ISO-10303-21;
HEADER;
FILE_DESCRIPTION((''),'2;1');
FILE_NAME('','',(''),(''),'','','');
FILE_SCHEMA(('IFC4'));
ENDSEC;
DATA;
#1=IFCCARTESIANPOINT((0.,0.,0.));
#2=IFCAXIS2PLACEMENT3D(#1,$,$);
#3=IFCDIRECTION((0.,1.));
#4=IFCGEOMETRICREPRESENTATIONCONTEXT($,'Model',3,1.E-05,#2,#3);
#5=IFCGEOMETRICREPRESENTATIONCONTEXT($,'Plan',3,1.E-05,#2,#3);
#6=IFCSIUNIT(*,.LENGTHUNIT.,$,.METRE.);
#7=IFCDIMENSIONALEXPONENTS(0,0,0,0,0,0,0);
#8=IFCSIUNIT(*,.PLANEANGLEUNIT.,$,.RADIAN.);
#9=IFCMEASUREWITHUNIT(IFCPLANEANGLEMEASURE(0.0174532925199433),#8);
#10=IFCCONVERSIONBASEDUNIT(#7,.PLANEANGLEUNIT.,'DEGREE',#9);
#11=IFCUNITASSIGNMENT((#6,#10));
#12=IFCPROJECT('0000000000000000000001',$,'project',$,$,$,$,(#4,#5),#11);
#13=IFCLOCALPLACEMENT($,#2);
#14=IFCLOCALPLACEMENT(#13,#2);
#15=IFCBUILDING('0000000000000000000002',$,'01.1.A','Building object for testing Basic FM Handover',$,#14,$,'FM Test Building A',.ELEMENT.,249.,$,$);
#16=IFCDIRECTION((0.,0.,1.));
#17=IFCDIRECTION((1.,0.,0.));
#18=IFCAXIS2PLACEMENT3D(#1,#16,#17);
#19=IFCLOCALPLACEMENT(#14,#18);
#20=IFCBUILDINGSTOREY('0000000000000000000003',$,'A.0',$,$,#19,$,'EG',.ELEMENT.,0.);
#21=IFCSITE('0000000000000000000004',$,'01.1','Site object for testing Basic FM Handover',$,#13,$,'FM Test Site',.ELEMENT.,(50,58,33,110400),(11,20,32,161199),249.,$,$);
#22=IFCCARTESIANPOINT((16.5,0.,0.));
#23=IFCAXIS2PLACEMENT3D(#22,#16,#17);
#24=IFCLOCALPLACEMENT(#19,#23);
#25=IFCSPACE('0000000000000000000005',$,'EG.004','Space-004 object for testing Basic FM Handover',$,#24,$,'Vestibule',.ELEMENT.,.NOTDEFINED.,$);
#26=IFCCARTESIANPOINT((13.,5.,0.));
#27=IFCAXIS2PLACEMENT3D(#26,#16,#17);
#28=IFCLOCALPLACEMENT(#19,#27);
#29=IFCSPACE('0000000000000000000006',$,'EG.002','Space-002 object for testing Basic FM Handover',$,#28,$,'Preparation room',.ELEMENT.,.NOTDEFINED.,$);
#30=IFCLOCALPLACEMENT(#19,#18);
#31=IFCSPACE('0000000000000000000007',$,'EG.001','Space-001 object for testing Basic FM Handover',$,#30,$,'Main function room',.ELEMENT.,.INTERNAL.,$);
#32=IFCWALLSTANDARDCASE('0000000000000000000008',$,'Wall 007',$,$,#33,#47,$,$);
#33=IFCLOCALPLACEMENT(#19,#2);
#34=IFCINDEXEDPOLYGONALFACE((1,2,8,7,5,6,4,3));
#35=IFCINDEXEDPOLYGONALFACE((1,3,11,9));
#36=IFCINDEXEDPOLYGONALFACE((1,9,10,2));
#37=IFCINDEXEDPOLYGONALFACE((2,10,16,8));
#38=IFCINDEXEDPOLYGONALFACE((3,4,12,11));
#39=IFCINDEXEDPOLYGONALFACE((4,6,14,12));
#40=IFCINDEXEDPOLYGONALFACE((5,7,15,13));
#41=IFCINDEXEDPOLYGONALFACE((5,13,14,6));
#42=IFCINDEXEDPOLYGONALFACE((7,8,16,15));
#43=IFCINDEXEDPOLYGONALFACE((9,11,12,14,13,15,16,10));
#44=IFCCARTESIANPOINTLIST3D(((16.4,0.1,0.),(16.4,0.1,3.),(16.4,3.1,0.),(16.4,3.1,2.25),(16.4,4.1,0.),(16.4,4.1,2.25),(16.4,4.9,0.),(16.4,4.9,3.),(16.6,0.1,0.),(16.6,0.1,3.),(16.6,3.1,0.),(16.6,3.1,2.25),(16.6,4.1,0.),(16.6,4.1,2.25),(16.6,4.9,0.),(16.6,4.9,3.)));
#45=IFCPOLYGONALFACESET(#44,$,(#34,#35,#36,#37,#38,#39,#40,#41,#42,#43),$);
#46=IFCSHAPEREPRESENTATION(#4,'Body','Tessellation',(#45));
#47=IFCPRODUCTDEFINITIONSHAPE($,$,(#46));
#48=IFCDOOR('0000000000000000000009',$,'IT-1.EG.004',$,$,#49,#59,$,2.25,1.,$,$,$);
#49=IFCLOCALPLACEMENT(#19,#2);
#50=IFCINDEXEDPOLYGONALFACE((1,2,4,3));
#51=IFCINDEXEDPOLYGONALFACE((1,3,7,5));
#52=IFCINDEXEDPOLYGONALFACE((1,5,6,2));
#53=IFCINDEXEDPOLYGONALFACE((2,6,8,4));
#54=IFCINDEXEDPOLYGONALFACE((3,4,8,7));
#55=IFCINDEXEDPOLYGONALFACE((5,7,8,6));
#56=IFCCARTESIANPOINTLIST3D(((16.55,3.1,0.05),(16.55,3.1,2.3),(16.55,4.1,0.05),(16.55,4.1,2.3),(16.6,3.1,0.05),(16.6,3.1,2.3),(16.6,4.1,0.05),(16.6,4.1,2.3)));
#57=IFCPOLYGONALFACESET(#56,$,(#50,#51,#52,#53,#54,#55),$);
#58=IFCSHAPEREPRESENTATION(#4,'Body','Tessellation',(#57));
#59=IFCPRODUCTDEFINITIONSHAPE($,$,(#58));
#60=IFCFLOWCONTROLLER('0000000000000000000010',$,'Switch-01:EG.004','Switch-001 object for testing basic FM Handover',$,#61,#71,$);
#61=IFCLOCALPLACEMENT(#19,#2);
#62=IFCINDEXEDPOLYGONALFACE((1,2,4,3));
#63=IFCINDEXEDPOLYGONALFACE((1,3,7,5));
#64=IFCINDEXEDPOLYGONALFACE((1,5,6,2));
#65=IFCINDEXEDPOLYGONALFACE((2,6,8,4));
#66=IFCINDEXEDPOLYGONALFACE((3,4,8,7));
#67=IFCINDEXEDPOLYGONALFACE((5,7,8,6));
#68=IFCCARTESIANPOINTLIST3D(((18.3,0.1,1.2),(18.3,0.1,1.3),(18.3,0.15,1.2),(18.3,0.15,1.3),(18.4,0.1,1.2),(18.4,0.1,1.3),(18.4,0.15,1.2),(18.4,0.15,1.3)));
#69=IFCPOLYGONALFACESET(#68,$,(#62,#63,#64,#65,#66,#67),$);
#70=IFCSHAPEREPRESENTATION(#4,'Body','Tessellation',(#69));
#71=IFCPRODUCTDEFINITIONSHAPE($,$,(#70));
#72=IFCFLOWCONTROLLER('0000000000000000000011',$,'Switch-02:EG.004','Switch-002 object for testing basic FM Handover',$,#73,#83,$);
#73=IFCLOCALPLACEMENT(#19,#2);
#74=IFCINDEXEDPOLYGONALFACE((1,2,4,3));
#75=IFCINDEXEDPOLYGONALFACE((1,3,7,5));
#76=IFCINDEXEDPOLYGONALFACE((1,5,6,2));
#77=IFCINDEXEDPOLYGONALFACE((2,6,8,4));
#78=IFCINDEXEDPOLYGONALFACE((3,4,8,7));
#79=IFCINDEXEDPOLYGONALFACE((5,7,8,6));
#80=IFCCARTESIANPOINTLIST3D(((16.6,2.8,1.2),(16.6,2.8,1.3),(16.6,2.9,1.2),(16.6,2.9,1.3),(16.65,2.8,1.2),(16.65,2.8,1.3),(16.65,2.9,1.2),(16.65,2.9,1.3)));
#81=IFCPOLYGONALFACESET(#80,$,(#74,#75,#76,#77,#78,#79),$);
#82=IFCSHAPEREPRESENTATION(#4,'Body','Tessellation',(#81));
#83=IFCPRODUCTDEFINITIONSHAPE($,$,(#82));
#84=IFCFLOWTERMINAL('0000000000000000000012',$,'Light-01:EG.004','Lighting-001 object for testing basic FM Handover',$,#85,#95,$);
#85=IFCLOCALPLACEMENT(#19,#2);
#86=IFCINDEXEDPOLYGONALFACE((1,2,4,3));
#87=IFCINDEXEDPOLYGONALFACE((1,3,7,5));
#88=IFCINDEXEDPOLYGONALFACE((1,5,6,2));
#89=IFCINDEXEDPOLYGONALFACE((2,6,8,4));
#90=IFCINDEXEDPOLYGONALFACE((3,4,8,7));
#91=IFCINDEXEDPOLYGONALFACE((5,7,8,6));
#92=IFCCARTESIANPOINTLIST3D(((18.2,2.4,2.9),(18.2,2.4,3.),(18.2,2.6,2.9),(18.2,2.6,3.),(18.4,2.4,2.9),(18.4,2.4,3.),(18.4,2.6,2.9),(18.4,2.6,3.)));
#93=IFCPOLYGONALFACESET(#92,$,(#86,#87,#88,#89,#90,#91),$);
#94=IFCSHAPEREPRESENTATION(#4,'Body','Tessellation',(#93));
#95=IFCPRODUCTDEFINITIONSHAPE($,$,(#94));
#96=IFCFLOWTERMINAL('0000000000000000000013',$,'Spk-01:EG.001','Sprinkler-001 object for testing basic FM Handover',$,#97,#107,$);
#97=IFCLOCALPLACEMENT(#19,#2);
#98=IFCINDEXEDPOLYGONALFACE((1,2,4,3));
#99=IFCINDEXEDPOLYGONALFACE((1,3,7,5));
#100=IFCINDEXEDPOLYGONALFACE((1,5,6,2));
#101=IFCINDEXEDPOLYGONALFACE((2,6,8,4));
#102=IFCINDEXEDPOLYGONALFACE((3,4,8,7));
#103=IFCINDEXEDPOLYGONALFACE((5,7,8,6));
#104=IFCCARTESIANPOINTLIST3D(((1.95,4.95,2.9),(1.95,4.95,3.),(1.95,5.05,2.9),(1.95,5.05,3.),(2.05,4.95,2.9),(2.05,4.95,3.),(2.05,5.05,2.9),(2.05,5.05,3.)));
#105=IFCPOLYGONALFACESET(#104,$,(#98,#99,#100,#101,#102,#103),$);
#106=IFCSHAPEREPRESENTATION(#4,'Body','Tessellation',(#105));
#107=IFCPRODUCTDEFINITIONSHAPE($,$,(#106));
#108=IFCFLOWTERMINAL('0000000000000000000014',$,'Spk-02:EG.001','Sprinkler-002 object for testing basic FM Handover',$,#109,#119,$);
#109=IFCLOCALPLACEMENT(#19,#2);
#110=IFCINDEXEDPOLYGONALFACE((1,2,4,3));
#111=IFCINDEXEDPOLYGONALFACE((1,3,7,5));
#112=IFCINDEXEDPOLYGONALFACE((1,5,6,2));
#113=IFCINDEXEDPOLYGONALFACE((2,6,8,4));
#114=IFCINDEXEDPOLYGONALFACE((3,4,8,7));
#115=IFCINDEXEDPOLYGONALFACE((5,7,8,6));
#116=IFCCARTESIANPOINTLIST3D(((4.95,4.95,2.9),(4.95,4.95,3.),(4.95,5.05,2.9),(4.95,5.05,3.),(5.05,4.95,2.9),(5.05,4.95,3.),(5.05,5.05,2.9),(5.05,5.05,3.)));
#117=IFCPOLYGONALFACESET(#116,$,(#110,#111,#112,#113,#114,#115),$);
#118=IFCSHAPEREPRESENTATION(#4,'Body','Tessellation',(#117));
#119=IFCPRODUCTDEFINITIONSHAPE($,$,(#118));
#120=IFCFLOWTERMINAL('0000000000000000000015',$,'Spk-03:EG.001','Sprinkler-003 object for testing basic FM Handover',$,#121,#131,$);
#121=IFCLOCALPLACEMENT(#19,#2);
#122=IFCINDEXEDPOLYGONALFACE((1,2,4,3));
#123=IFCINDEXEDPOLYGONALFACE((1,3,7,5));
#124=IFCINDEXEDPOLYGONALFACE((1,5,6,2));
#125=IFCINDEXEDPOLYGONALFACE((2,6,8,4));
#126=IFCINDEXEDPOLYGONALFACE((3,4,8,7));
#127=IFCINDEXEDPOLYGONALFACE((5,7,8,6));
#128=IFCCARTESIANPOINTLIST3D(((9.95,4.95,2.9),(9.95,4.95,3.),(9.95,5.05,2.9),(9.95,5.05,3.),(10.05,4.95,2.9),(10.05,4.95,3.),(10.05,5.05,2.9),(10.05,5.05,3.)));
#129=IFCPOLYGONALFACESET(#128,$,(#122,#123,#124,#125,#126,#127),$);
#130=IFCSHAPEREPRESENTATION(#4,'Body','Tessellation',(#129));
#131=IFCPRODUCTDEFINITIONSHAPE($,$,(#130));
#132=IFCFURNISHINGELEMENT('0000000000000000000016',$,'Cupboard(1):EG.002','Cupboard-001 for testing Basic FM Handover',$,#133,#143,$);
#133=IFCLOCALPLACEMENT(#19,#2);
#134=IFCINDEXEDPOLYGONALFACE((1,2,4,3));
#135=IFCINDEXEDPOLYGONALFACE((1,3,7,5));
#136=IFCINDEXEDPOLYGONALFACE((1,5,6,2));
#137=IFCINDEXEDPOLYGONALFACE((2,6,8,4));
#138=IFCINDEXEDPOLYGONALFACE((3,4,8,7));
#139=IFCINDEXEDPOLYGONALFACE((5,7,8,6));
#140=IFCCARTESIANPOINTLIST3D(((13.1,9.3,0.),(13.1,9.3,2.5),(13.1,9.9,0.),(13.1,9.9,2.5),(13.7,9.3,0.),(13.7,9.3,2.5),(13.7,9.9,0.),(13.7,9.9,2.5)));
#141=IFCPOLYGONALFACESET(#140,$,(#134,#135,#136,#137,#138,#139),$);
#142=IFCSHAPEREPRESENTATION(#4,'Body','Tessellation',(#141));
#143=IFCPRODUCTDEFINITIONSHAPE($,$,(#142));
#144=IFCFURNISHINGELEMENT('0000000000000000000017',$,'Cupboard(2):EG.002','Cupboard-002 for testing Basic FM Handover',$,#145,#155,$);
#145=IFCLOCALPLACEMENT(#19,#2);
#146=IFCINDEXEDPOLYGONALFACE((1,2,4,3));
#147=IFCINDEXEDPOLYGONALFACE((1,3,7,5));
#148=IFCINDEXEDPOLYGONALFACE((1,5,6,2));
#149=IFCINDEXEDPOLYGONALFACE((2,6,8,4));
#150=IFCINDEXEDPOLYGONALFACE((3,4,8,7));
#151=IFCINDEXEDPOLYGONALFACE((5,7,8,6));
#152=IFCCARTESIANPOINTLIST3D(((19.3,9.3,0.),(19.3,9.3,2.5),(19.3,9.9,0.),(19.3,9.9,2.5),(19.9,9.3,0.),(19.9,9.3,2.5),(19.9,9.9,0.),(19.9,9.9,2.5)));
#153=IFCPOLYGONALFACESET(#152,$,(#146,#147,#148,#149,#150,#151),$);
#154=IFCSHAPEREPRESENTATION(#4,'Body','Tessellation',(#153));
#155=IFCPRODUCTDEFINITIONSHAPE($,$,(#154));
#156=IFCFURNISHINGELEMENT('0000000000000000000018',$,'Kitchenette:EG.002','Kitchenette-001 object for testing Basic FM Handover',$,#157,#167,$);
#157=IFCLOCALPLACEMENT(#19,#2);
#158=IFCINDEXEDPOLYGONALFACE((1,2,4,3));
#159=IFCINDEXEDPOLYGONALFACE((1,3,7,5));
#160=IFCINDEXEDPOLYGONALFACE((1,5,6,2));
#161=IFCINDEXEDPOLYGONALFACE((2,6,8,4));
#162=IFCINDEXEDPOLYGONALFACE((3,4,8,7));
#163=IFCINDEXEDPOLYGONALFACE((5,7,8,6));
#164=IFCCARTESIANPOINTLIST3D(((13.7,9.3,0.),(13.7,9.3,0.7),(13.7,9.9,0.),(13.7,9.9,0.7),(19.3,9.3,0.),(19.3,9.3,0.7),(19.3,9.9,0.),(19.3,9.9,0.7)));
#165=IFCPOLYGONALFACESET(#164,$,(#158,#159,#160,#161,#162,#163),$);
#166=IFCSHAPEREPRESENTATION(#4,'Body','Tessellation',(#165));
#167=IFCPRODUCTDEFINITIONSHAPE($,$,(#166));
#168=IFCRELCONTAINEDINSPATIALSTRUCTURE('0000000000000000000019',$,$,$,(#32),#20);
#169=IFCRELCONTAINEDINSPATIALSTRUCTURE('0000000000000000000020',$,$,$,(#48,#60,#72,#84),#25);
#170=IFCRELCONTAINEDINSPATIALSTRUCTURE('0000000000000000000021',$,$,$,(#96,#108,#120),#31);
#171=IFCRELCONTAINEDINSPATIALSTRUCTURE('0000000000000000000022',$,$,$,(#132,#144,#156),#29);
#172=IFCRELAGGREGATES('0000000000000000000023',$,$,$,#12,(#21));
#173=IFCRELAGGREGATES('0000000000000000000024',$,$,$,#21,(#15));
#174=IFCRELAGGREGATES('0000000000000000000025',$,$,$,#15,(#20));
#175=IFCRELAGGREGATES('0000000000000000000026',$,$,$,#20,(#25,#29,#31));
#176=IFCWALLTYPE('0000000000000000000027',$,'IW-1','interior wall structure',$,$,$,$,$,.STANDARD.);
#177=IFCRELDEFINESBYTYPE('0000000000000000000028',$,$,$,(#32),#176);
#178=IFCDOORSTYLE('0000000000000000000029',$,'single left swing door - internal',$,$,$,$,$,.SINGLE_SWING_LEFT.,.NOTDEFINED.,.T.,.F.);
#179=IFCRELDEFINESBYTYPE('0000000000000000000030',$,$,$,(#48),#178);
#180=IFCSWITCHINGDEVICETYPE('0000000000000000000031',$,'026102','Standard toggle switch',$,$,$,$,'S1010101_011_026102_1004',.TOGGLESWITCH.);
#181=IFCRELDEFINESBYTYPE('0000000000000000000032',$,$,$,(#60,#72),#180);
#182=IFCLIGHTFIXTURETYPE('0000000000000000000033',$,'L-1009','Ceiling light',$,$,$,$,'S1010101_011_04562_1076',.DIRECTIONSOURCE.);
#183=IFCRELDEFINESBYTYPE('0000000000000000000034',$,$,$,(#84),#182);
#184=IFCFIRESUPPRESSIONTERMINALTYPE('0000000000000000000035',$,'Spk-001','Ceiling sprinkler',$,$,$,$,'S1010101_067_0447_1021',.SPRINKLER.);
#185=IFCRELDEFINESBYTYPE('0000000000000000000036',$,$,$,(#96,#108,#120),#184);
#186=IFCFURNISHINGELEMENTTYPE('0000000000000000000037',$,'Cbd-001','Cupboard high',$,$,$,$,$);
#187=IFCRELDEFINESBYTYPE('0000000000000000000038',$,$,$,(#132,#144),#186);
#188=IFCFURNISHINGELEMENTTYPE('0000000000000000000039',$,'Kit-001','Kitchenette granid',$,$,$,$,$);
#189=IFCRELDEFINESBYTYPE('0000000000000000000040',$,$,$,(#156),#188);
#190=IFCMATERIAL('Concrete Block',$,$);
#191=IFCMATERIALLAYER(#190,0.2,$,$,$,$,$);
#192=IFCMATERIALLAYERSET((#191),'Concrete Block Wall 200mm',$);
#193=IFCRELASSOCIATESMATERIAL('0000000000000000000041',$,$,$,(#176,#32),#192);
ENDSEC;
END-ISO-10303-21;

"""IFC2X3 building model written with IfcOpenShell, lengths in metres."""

from ifc_helpers import new_model, entity, si_unit, converted_unit, direction, frame, frame_2d, origin, origin_with_axes, place, context, project, spatial, polyline, rectangle, outline, extrude, source, transform, mapped, material, layer, layer_set, layer_usage, type_object, type_shapes, element, fill, save


model = new_model("IFC2X3")

# Units and contexts
model_context = context("Model", 3, precision=1e-05, world=origin(), true_north=direction((0.0, 1.0)))
plan_context = context("Plan", 3, precision=1e-05, world=origin(), true_north=direction((0.0, 1.0)))
ifc_project = project(units=[si_unit("LENGTHUNIT", "METRE"), converted_unit("PLANEANGLEUNIT", "DEGREE", entity("IfcPlaneAngleMeasure", 0.0174532925199433), si_unit("PLANEANGLEUNIT", "RADIAN"), dimensions=[0, 0, 0, 0, 0, 0, 0])], contexts=[model_context, plan_context])

# Site, building, storey
site_placement = place(None, origin())
site = spatial("IfcSite", under=ifc_project, at=site_placement, Name="01.1", Description="Site object for testing Basic FM Handover", LongName="FM Test Site", CompositionType="ELEMENT", RefLatitude=(50, 58, 33, 110400), RefLongitude=(11, 20, 32, 161199), RefElevation=249.0)
building_placement = place(site_placement, origin())
building = spatial("IfcBuilding", under=site, at=building_placement, Name="01.1.A", Description="Building object for testing Basic FM Handover", LongName="FM Test Building A", CompositionType="ELEMENT", ElevationOfRefHeight=249.0)
storey_placement = place(building_placement, origin_with_axes())
storey = spatial("IfcBuildingStorey", under=building, at=storey_placement, Name="A.0", LongName="EG", CompositionType="ELEMENT", Elevation=0.0)

# Shared definitions
space_1_placement = place(storey_placement, frame((16.5, 0.0, 0.0), z_axis=(0.0, 0.0, 1.0), x_axis=(1.0, 0.0, 0.0)))
space_1 = spatial("IfcSpace", under=storey, at=space_1_placement, Name="EG.004", Description="Space-004 object for testing Basic FM Handover", LongName="Vestibule", CompositionType="ELEMENT", InteriorOrExteriorSpace="NOTDEFINED")

# Shared definitions
ifc_material_1 = material(Name="Concrete Block")
ifc_layer_1 = layer(ifc_material_1, 0.2)
ifc_layer_set_1 = layer_set([ifc_layer_1], Name="Concrete Block Wall 200mm")
wall_type_1 = type_object("IfcWallType", Name="IW-1", Description="interior wall structure", PredefinedType="STANDARD", material=ifc_layer_set_1)

# Wall, opening, door
ifc_layer_usage_1 = layer_usage(ifc_layer_set_1, "AXIS2", "POSITIVE", -0.1)
wall_1_placement = place(storey_placement, frame((16.5, 0.0, 0.0), z_axis=(0.0, 0.0, 1.0), x_axis=(0.0, 1.0, 0.0)))
wall_1 = element("IfcWallStandardCase", 1, at=wall_1_placement, inside=storey, type_object=wall_type_1, material=ifc_layer_usage_1, Name="Wall 007", context=model_context, shape_type="SweptSolid", body=[
    extrude(rectangle(XDim=4.8, YDim=0.2, at=frame_2d((2.5, 0.0))), origin(), (0.0, 0.0, 1.0), 3.0),
])
opening_1_placement = place(wall_1_placement, frame((4.1, 0.1, 0.0), z_axis=(0.0, 0.0, 1.0), x_axis=(-1.0, 0.0, 0.0)))
opening_1 = element("IfcOpeningElement", 2, at=opening_1_placement, cuts=wall_1, context=model_context, shape_type="SweptSolid", body=[
    extrude(rectangle(XDim=2.25, YDim=1.0, at=frame_2d((1.125, 0.5))), frame((0.0, 0.0, 0.0), z_axis=(0.0, 1.0, 0.0), x_axis=(0.0, 0.0, 1.0)), (0.0, 0.0, 1.0), 0.2),
])
door_style_1 = type_object("IfcDoorStyle", Name="single left swing door - internal", ConstructionType="NOTDEFINED", OperationType="SINGLE_SWING_LEFT", ParameterTakesPrecedence=True, Sizeable=False)
door_1_placement = place(opening_1_placement, origin_with_axes())
door_1 = element("IfcDoor", 3, at=door_1_placement, inside=space_1, type_object=door_style_1, Name="IT-1.EG.004", OverallHeight=2.25, OverallWidth=1.0, context=model_context, shape_type="SweptSolid", body=[
    extrude(rectangle(XDim=2.25, YDim=1.0, at=frame_2d((1.075, 0.5))), frame((0.0, 0.15, 0.1), z_axis=(0.0, 1.0, 0.0), x_axis=(0.0, 0.0, 1.0)), (0.0, 0.0, 1.0), 0.05),
])
fill(opening_1, door_1)

# Shared definitions
space_2_placement = place(storey_placement, frame((13.0, 5.0, 0.0), z_axis=(0.0, 0.0, 1.0), x_axis=(1.0, 0.0, 0.0)))
space_2 = spatial("IfcSpace", under=storey, at=space_2_placement, Name="EG.002", Description="Space-002 object for testing Basic FM Handover", LongName="Preparation room", CompositionType="ELEMENT", InteriorOrExteriorSpace="NOTDEFINED")

# Flow controllers
switching_device_type = type_object("IfcSwitchingDeviceType", Name="026102", Description="Standard toggle switch", ElementType="S1010101_011_026102_1004", PredefinedType="TOGGLESWITCH")
shared_shape_1 = source(origin_with_axes(), model_context, "Body", "SweptSolid", [
    extrude(outline(polyline([(0.0, 0.0), (0.1, 0.0), (0.1, 0.05), (0.0, 0.05), (0.0, 0.0)])), origin(), (0.0, 0.0, 1.0), 0.1),
])
type_shapes(switching_device_type, [shared_shape_1])
for number, where, z_axis, x_axis, name, description in (
    (4, (18.3, 0.1, 1.2), (0.0, 0.0, 1.0), (1.0, 0.0, 0.0), "Switch-01:EG.004", "Switch-001 object for testing basic FM Handover"),
    (5, (16.65, 2.8, 1.2), (0.0, 0.0, 1.0), (0.0, 1.0, 0.0), "Switch-02:EG.004", "Switch-002 object for testing basic FM Handover"),
):
    element("IfcFlowController", number, at=place(storey_placement, frame(where, z_axis=z_axis, x_axis=x_axis)), inside=space_1, type_object=switching_device_type, Name=name, Description=description, context=model_context, shape_type="MappedRepresentation", body=[
        mapped(shared_shape_1, transform((0.0, 0.0, 0.0))),
    ])

# Flow terminal
light_fixture_type = type_object("IfcLightFixtureType", Name="L-1009", Description="Ceiling light", ElementType="S1010101_011_04562_1076", PredefinedType="DIRECTIONSOURCE")
shared_shape_2 = source(origin_with_axes(), model_context, "Body", "SweptSolid", [
    extrude(outline(polyline([(-0.1, -0.1), (0.1, -0.1), (0.1, 0.1), (-0.1, 0.1), (-0.1, -0.1)])), origin(), (0.0, 0.0, 1.0), 0.1),
])
type_shapes(light_fixture_type, [shared_shape_2])
flow_terminal_placement = place(storey_placement, frame((18.3, 2.5, 2.9), z_axis=(0.0, 0.0, 1.0), x_axis=(1.0, 0.0, 0.0)))
element("IfcFlowTerminal", 6, at=flow_terminal_placement, inside=space_1, type_object=light_fixture_type, Name="Light-01:EG.004", Description="Lighting-001 object for testing basic FM Handover", context=model_context, shape_type="MappedRepresentation", body=[
    mapped(shared_shape_2, transform((0.0, 0.0, 0.0))),
])

# Shared definitions
space_3_placement = place(storey_placement, origin_with_axes())
space_3 = spatial("IfcSpace", under=storey, at=space_3_placement, Name="EG.001", Description="Space-001 object for testing Basic FM Handover", LongName="Main function room", CompositionType="ELEMENT", InteriorOrExteriorSpace="INTERNAL")

# Flow terminals
fire_suppression_terminal_type = type_object("IfcFireSuppressionTerminalType", Name="Spk-001", Description="Ceiling sprinkler", ElementType="S1010101_067_0447_1021", PredefinedType="SPRINKLER")
shared_shape_3 = source(origin_with_axes(), model_context, "Body", "SweptSolid", [
    extrude(outline(polyline([(-0.05, -0.05), (0.05, -0.05), (0.05, 0.05), (-0.05, 0.05), (-0.05, -0.05)])), origin(), (0.0, 0.0, 1.0), 0.1),
])
type_shapes(fire_suppression_terminal_type, [shared_shape_3])
for number, where, z_axis, x_axis, name, description in (
    (7, (2.0, 5.0, 2.9), (0.0, 0.0, 1.0), (1.0, 0.0, 0.0), "Spk-01:EG.001", "Sprinkler-001 object for testing basic FM Handover"),
    (8, (5.0, 5.0, 2.9), (0.0, 0.0, 1.0), (1.0, 0.0, 0.0), "Spk-02:EG.001", "Sprinkler-002 object for testing basic FM Handover"),
    (9, (10.0, 5.0, 2.9), (0.0, 0.0, 1.0), (1.0, 0.0, 0.0), "Spk-03:EG.001", "Sprinkler-003 object for testing basic FM Handover"),
):
    element("IfcFlowTerminal", number, at=place(storey_placement, frame(where, z_axis=z_axis, x_axis=x_axis)), inside=space_3, type_object=fire_suppression_terminal_type, Name=name, Description=description, context=model_context, shape_type="MappedRepresentation", body=[
        mapped(shared_shape_3, transform((0.0, 0.0, 0.0))),
    ])

# Furnishing elements
furnishing_element_type_1 = type_object("IfcFurnishingElementType", Name="Cbd-001", Description="Cupboard high")
shared_shape_4 = source(origin_with_axes(), model_context, "Body", "SweptSolid", [
    extrude(rectangle(XDim=0.6, YDim=0.6, at=frame_2d((0.3, 0.3))), origin(), (0.0, 0.0, 1.0), 2.5),
])
type_shapes(furnishing_element_type_1, [shared_shape_4])
for number, where, z_axis, x_axis, name, description in (
    (10, (13.1, 9.3, 0.0), (0.0, 0.0, 1.0), (1.0, 0.0, 0.0), "Cupboard(1):EG.002", "Cupboard-001 for testing Basic FM Handover"),
    (11, (19.3, 9.3, 0.0), (0.0, 0.0, 1.0), (1.0, 0.0, 0.0), "Cupboard(2):EG.002", "Cupboard-002 for testing Basic FM Handover"),
):
    element("IfcFurnishingElement", number, at=place(storey_placement, frame(where, z_axis=z_axis, x_axis=x_axis)), inside=space_2, type_object=furnishing_element_type_1, Name=name, Description=description, context=model_context, shape_type="MappedRepresentation", body=[
        mapped(shared_shape_4, transform((0.0, 0.0, 0.0))),
    ])
furnishing_element_type_2 = type_object("IfcFurnishingElementType", Name="Kit-001", Description="Kitchenette granid")
furnishing_placement = place(storey_placement, frame((13.7, 9.3, 0.0), z_axis=(0.0, 0.0, 1.0), x_axis=(1.0, 0.0, 0.0)))
element("IfcFurnishingElement", 12, at=furnishing_placement, inside=space_2, type_object=furnishing_element_type_2, Name="Kitchenette:EG.002", Description="Kitchenette-001 object for testing Basic FM Handover", context=model_context, shape_type="SweptSolid", body=[
    extrude(rectangle(XDim=5.6, YDim=0.6, at=frame_2d((2.8, 0.3))), origin(), (0.0, 0.0, 1.0), 0.7),
])

save(model, "model.ifc")
